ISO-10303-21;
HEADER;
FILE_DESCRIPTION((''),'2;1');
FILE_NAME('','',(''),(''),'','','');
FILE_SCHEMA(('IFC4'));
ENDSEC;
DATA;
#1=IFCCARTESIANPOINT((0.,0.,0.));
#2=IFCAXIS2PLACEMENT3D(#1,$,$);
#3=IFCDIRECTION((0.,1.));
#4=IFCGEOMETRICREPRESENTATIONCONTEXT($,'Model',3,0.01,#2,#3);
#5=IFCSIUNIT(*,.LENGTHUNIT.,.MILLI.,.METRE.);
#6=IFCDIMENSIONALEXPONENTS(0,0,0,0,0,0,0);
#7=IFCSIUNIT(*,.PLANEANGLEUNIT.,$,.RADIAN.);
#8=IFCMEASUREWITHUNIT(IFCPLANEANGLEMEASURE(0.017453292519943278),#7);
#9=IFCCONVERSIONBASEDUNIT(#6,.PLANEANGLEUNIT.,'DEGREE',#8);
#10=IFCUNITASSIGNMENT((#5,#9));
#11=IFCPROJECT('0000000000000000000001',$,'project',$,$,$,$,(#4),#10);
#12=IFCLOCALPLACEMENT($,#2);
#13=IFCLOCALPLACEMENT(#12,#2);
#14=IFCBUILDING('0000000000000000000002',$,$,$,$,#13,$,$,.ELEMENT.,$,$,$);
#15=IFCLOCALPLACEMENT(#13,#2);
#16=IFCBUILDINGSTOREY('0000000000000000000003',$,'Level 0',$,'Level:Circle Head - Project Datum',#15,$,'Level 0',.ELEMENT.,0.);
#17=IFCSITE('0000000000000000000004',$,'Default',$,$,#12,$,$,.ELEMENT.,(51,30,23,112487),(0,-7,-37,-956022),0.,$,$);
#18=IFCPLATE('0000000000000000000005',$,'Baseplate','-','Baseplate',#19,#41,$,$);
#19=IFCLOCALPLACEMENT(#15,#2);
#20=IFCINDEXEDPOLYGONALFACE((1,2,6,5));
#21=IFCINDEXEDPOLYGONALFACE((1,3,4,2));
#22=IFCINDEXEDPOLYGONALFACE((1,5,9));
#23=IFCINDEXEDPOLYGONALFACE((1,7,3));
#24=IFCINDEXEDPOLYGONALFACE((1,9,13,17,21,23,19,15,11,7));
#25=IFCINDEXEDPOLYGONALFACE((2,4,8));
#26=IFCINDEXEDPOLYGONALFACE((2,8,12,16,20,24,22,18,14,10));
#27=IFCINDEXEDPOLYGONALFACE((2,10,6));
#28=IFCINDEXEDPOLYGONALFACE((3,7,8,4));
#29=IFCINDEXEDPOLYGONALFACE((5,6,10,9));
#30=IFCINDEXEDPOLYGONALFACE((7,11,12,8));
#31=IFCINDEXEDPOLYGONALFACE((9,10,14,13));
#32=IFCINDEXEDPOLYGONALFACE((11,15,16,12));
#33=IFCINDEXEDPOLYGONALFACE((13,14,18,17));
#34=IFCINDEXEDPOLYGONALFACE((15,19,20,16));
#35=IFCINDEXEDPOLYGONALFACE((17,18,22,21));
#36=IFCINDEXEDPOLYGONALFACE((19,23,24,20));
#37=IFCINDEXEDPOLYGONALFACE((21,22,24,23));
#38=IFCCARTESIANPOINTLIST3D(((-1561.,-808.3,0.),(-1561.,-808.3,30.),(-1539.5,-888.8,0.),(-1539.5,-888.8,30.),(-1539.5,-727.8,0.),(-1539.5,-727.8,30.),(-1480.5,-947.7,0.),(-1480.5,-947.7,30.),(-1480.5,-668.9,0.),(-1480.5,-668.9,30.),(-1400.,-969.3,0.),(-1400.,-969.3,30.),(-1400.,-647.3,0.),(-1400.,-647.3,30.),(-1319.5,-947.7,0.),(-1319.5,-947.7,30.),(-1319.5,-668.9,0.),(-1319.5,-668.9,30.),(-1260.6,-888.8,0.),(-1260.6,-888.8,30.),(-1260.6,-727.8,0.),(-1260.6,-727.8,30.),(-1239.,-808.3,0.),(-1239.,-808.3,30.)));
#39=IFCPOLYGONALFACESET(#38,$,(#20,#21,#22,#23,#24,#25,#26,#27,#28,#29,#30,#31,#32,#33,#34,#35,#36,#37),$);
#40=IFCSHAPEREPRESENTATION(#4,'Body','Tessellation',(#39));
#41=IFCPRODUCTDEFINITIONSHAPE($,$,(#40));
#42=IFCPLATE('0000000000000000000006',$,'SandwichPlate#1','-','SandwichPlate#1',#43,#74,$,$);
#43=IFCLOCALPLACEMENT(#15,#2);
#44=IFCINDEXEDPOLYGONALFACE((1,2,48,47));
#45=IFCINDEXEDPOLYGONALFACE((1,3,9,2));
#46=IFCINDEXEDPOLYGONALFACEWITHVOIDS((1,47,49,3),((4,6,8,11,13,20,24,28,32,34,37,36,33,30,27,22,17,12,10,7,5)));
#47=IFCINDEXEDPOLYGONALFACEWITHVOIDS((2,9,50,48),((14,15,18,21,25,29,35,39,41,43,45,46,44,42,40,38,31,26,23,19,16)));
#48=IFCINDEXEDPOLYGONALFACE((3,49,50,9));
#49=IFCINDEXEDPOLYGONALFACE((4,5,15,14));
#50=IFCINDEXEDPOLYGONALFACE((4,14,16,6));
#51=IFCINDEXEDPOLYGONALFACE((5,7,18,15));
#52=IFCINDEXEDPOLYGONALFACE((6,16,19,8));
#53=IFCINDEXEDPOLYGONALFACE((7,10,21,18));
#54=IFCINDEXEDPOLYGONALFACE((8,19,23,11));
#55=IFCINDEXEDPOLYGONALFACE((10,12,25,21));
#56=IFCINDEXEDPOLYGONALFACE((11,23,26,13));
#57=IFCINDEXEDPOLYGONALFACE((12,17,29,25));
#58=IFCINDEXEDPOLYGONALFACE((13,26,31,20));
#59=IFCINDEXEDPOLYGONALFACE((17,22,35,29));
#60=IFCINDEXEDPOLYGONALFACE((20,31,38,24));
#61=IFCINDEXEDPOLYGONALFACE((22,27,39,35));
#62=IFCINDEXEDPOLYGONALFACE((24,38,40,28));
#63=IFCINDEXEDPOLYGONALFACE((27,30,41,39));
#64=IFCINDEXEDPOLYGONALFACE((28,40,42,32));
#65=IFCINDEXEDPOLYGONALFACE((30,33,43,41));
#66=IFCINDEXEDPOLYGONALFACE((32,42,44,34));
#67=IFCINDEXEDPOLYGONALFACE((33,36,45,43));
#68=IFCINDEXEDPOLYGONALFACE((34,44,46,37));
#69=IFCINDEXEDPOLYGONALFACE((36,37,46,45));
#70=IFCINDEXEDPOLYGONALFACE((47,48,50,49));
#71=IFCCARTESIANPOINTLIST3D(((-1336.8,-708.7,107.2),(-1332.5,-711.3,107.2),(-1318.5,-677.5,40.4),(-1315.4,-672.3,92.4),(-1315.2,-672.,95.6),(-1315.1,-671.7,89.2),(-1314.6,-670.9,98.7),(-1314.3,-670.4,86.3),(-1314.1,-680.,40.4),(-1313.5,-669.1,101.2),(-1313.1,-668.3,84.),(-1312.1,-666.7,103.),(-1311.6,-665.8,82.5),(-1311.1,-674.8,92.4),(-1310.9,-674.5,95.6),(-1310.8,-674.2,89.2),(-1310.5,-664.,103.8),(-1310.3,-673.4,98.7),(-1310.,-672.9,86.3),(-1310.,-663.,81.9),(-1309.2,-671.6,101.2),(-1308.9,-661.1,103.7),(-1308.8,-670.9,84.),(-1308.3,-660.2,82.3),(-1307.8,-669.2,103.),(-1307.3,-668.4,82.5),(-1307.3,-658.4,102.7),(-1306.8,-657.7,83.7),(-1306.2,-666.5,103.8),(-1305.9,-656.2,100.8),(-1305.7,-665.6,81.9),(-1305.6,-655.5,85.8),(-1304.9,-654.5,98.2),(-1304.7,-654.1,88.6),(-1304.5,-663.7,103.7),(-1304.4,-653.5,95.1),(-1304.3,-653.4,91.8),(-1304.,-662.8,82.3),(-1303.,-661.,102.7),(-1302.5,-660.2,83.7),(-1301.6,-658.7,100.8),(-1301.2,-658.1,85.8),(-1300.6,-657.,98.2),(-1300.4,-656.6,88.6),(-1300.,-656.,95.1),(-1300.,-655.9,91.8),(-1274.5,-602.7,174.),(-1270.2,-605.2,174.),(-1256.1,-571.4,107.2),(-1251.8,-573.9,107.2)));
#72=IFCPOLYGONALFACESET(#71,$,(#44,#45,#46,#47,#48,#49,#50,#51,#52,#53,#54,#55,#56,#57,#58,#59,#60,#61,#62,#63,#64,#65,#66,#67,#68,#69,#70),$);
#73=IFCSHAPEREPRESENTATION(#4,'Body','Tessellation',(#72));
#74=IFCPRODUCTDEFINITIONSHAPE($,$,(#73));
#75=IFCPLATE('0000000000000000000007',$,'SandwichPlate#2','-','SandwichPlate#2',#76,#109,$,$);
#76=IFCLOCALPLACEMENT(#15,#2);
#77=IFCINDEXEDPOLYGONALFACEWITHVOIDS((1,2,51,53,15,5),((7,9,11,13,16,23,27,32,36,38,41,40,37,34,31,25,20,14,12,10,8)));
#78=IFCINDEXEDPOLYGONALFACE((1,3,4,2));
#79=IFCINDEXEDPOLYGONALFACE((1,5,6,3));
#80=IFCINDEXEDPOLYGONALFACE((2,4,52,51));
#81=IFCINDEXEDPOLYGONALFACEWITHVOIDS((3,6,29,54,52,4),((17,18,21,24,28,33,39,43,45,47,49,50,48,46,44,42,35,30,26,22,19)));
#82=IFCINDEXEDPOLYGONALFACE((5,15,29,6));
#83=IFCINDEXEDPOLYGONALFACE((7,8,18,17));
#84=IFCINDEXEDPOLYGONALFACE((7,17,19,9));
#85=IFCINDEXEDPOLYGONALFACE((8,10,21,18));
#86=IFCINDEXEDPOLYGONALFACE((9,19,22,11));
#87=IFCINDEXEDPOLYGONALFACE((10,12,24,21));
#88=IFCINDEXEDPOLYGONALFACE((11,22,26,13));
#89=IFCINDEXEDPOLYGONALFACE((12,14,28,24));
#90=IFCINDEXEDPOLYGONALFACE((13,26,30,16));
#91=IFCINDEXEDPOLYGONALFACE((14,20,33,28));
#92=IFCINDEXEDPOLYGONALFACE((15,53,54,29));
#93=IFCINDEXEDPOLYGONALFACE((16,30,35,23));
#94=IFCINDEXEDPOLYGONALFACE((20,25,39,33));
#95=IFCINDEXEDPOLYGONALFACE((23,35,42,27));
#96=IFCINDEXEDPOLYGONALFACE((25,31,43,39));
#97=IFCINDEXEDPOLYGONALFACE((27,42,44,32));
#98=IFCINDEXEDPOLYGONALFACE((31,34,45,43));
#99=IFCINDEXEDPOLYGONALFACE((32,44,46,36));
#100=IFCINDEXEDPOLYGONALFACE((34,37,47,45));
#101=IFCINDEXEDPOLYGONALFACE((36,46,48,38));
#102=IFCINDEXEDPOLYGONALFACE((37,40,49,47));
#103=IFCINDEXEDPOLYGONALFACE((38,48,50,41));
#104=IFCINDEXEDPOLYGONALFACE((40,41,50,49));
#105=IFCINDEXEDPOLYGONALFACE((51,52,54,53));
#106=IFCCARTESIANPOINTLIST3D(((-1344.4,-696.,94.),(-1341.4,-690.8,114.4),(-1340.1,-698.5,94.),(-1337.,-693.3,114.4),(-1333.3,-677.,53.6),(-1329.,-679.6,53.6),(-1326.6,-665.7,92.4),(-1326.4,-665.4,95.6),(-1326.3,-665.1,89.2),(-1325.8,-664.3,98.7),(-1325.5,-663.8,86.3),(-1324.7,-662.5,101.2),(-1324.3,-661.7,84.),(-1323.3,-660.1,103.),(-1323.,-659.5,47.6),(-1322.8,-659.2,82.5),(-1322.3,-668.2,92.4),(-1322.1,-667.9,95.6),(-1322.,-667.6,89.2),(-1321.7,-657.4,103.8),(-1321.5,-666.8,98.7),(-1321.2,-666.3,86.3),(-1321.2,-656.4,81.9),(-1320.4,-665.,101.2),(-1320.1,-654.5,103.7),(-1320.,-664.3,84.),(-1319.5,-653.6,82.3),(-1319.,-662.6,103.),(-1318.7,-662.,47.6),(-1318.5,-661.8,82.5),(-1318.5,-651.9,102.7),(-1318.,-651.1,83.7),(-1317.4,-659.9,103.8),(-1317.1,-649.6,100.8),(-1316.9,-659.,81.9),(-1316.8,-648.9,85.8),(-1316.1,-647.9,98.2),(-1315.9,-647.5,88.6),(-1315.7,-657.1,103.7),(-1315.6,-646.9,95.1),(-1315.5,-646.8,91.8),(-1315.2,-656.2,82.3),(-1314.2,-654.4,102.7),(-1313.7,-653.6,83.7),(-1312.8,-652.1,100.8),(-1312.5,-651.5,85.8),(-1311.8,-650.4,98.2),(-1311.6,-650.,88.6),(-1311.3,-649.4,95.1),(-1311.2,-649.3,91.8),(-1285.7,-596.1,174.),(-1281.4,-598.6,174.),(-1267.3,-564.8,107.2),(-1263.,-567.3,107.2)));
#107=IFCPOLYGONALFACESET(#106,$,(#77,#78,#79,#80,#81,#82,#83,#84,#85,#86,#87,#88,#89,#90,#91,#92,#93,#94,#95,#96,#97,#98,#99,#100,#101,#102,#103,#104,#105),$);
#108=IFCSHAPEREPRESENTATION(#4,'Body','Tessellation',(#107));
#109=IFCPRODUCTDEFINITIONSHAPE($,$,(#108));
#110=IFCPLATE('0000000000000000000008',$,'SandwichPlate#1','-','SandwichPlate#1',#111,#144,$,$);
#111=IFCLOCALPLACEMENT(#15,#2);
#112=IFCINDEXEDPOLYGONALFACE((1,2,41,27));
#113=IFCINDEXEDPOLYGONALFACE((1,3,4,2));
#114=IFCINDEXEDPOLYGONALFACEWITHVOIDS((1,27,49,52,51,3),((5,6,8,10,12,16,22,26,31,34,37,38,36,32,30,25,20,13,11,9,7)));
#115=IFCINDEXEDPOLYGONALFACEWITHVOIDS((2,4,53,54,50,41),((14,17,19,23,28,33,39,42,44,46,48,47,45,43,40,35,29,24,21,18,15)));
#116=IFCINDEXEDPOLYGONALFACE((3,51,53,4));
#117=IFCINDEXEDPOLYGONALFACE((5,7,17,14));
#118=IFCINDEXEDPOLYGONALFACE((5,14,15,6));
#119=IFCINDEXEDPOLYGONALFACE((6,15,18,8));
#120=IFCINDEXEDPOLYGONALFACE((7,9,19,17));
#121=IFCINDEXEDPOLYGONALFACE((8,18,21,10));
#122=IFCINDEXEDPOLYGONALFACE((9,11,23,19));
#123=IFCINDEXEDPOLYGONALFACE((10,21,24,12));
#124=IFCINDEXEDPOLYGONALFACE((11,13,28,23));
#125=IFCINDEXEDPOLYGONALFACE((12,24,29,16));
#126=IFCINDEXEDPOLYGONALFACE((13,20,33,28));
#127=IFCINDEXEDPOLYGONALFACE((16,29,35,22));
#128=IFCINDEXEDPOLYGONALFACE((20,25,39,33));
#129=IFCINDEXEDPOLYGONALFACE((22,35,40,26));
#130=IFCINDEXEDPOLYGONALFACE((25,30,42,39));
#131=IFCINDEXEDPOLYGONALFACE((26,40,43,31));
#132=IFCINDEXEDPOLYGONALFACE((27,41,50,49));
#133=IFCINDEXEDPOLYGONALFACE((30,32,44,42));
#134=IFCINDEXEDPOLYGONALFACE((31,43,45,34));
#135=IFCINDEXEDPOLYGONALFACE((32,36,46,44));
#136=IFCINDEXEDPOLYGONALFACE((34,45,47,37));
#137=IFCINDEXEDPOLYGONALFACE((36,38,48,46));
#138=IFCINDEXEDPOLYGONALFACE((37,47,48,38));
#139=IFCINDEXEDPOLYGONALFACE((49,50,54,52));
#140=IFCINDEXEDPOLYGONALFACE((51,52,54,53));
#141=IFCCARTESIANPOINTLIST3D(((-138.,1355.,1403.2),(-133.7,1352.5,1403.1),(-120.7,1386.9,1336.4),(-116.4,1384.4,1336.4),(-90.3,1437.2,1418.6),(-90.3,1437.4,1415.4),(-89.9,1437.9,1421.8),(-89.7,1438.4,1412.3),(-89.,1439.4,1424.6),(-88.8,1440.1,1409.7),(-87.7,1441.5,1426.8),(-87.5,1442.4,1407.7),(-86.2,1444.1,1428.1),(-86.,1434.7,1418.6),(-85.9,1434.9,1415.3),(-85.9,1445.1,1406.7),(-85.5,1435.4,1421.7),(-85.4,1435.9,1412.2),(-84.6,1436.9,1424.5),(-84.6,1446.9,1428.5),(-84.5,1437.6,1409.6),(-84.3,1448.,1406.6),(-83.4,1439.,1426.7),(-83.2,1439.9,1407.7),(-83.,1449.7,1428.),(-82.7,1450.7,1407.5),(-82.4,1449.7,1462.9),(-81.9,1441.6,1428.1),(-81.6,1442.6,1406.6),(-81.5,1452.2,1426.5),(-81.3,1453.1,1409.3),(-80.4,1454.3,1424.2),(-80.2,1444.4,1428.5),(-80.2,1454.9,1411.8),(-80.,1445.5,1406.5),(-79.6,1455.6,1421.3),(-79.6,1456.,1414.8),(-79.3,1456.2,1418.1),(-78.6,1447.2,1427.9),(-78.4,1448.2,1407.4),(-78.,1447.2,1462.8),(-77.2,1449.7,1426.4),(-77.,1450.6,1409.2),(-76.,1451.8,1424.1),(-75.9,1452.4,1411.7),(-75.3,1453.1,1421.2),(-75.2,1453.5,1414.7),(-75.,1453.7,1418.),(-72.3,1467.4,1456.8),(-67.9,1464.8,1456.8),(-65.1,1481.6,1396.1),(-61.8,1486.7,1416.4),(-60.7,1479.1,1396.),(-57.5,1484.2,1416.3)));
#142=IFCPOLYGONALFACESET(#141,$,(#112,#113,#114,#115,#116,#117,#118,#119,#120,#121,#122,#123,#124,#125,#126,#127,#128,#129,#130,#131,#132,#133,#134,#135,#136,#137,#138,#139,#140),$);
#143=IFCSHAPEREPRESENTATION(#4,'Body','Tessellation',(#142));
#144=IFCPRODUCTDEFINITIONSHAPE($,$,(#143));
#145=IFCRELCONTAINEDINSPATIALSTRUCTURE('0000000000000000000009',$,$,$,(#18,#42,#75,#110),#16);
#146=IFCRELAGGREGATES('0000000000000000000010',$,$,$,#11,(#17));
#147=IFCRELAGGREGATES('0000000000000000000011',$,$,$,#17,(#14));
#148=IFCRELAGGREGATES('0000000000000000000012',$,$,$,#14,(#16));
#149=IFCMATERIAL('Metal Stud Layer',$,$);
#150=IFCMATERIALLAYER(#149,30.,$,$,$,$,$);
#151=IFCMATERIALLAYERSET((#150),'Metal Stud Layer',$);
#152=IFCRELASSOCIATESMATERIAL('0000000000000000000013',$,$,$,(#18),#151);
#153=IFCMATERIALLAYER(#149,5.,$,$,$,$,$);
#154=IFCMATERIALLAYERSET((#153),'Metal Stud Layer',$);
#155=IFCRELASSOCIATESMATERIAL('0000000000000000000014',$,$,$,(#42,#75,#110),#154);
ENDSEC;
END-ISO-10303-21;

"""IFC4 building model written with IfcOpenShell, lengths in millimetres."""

from ifc_helpers import new_model, entity, si_unit, converted_unit, point, direction, frame, frame_2d, origin, origin_with_axes, origin_2d_with_axis, place, context, project, spatial, polyline, circle_curve, line_curve, trimmed, segment, composite_curve, circle, outline, extrude, material, layer, layer_set, element, save


model = new_model("IFC4")

# Units and contexts
model_context = context("Model", 3, precision=0.01, world=origin(), true_north=direction((0.0, 1.0)))
ifc_project = project(units=[si_unit("LENGTHUNIT", "METRE", prefix="MILLI"), converted_unit("PLANEANGLEUNIT", "DEGREE", entity("IfcPlaneAngleMeasure", 0.017453292519943278), si_unit("PLANEANGLEUNIT", "RADIAN"), dimensions=[0, 0, 0, 0, 0, 0, 0])], contexts=[model_context])

# Site, building, storey
site_placement = place(None, origin())
site = spatial("IfcSite", under=ifc_project, at=site_placement, Name="Default", CompositionType="ELEMENT", RefLatitude=(51, 30, 23, 112487), RefLongitude=(0, -7, -37, -956022), RefElevation=0.0)
building_placement = place(site_placement, origin())
building = spatial("IfcBuilding", under=site, at=building_placement, CompositionType="ELEMENT")
storey_placement = place(building_placement, origin())
storey = spatial("IfcBuildingStorey", under=building, at=storey_placement, Name="Level 0", ObjectType="Level:Circle Head - Project Datum", LongName="Level 0", CompositionType="ELEMENT", Elevation=0.0)

# Plate, openings
ifc_material_1 = material(Name="Metal Stud Layer")
ifc_layer_1 = layer(ifc_material_1, 30.0)
ifc_layer_set_1 = layer_set([ifc_layer_1], Name="Metal Stud Layer")
ifc_layer_2 = layer(ifc_material_1, 5.0)
ifc_layer_set_2 = layer_set([ifc_layer_2], Name="Metal Stud Layer")
plate_1_placement = place(storey_placement, frame((-1319.5, -947.7, 30.0), z_axis=(0.0, 0.0, -1.0), x_axis=(-0.866025, -0.5, 0.0)))
plate_1 = element("IfcPlate", 1, at=plate_1_placement, inside=storey, material=ifc_layer_set_1, Name="Baseplate", Description="-", ObjectType="Baseplate", context=model_context, shape_type="SweptSolid", body=[
    extrude(outline(polyline([(161.0, 0.0), (161.0, 322.0), (-161.0, 322.0), (-161.0, 0.0), (161.0, 0.0)])), origin_with_axes(), (0.0, 0.0, 1.0), 30.0),
])
opening_1_placement = place(plate_1_placement, frame((0.0, 0.0, 0.0), z_axis=(0.0, 0.0, 1.0), x_axis=(1.0, 0.0, 0.0)))
element("IfcOpeningElement", 2, at=opening_1_placement, cuts=plate_1, ObjectType="Opening", context=model_context, shape_type="SweptSolid", body=[
    extrude(outline(composite_curve([segment(trimmed(line_curve((161.0, 0.0), (0.0, 1.0), 161.0), [point((161.0, 0.0))], [point((161.0, 161.0))], True, "CARTESIAN"), True, "CONTINUOUS"), segment(trimmed(circle_curve(frame_2d((0.0, 161.0), x_axis=(-1.0, 0.0)), 161.0), [point((161.0, 161.0))], [point((0.0, 0.0))], False, "CARTESIAN"), True, "CONTINUOUS"), segment(trimmed(line_curve((0.0, 0.0), (1.0, 0.0), 161.0), [point((0.0, 0.0))], [point((161.0, 0.0))], True, "CARTESIAN"), True, "CONTINUOUS")], self_intersect="UNKNOWN")), origin(), (0.0, 0.0, 1.0), 30.0),
])
opening_2_placement = place(plate_1_placement, frame((0.0, 0.0, 0.0), z_axis=(0.0, 0.0, 1.0), x_axis=(1.0, 0.0, 0.0)))
element("IfcOpeningElement", 3, at=opening_2_placement, cuts=plate_1, ObjectType="Opening", context=model_context, shape_type="SweptSolid", body=[
    extrude(outline(composite_curve([segment(trimmed(line_curve((161.0, 322.0), (-1.0, 0.0), 161.0), [point((161.0, 322.0))], [point((0.0, 322.0))], True, "CARTESIAN"), True, "CONTINUOUS"), segment(trimmed(circle_curve(frame_2d((0.0, 161.0), x_axis=(-1.0, 0.0)), 161.0), [point((0.0, 322.0))], [point((161.0, 161.0))], False, "CARTESIAN"), True, "CONTINUOUS"), segment(trimmed(line_curve((161.0, 161.0), (0.0, 1.0), 161.0), [point((161.0, 161.0))], [point((161.0, 322.0))], True, "CARTESIAN"), True, "CONTINUOUS")], self_intersect="UNKNOWN")), origin(), (0.0, 0.0, 1.0), 30.0),
])
opening_3_placement = place(plate_1_placement, frame((0.0, 0.0, 0.0), z_axis=(0.0, 0.0, 1.0), x_axis=(1.0, 0.0, 0.0)))
element("IfcOpeningElement", 4, at=opening_3_placement, cuts=plate_1, ObjectType="Opening", context=model_context, shape_type="SweptSolid", body=[
    extrude(outline(composite_curve([segment(trimmed(line_curve((-161.0, 322.0), (0.0, -1.0), 161.0), [point((-161.0, 322.0))], [point((-161.0, 161.0))], True, "CARTESIAN"), True, "CONTINUOUS"), segment(trimmed(circle_curve(frame_2d((0.0, 161.0), x_axis=(-1.0, 0.0)), 161.0), [point((-161.0, 161.0))], [point((0.0, 322.0))], False, "CARTESIAN"), True, "CONTINUOUS"), segment(trimmed(line_curve((0.0, 322.0), (-1.0, 0.0), 161.0), [point((0.0, 322.0))], [point((-161.0, 322.0))], True, "CARTESIAN"), True, "CONTINUOUS")], self_intersect="UNKNOWN")), origin(), (0.0, 0.0, 1.0), 30.0),
])
opening_4_placement = place(plate_1_placement, frame((0.0, 0.0, 0.0), z_axis=(0.0, 0.0, 1.0), x_axis=(1.0, 0.0, 0.0)))
element("IfcOpeningElement", 5, at=opening_4_placement, cuts=plate_1, ObjectType="Opening", context=model_context, shape_type="SweptSolid", body=[
    extrude(outline(composite_curve([segment(trimmed(line_curve((-161.0, 0.0), (1.0, 0.0), 161.0), [point((-161.0, 0.0))], [point((0.0, 0.0))], True, "CARTESIAN"), True, "CONTINUOUS"), segment(trimmed(circle_curve(frame_2d((0.0, 161.0), x_axis=(-1.0, 0.0)), 161.0), [point((0.0, 0.0))], [point((-161.0, 161.0))], False, "CARTESIAN"), True, "CONTINUOUS"), segment(trimmed(line_curve((-161.0, 161.0), (0.0, -1.0), 161.0), [point((-161.0, 161.0))], [point((-161.0, 0.0))], True, "CARTESIAN"), True, "CONTINUOUS")], self_intersect="UNKNOWN")), origin(), (0.0, 0.0, 1.0), 30.0),
])

# Plates, openings
plate_2_placement = place(storey_placement, frame((-1336.8, -708.7, 107.2), z_axis=(0.86208, -0.506772, 0.0), x_axis=(0.24181, 0.411348, -0.878818)))
plate_2 = element("IfcPlate", 6, at=plate_2_placement, inside=storey, material=ifc_layer_set_2, Name="SandwichPlate#1", Description="-", ObjectType="SandwichPlate#1", context=model_context, shape_type="SweptSolid", body=[
    extrude(outline(polyline([(0.0, 0.0), (76.0, 0.0), (76.0, 140.0), (0.0, 140.0), (0.0, 0.0)])), origin_with_axes(), (0.0, 0.0, 1.0), 5.0),
])
opening_5_placement = place(plate_2_placement, frame((38.0, 40.0, -0.5), z_axis=(0.0, 0.0, 1.0), x_axis=(0.0, 1.0, 0.0)))
element("IfcOpeningElement", 7, at=opening_5_placement, cuts=plate_2, ObjectType="Opening", context=model_context, shape_type="SweptSolid", body=[
    extrude(circle(Radius=11.0, at=origin_2d_with_axis()), origin(), (0.0, 0.0, 1.0), 6.0),
])
plate_3_placement = place(storey_placement, frame((-1348.0, -702.1, 107.2), z_axis=(0.86208, -0.506772, 0.0), x_axis=(0.24181, 0.411348, -0.878818)))
plate_3 = element("IfcPlate", 8, at=plate_3_placement, inside=storey, material=ifc_layer_set_2, Name="SandwichPlate#2", Description="-", ObjectType="SandwichPlate#2", context=model_context, shape_type="SweptSolid", body=[
    extrude(outline(polyline([(15.0, 0.0), (61.0, 0.0), (76.0, 15.0), (76.0, 140.0), (0.0, 140.0), (0.0, 15.0), (15.0, 0.0)])), origin_with_axes(), (0.0, 0.0, 1.0), 5.0),
])
opening_6_placement = place(plate_3_placement, frame((38.0, 40.0, -0.5), z_axis=(0.0, 0.0, 1.0), x_axis=(0.0, 1.0, 0.0)))
element("IfcOpeningElement", 9, at=opening_6_placement, cuts=plate_3, ObjectType="Opening", context=model_context, shape_type="SweptSolid", body=[
    extrude(circle(Radius=11.0, at=origin_2d_with_axis()), origin(), (0.0, 0.0, 1.0), 6.0),
])

# Plate, openings
plate_4_placement = place(storey_placement, frame((-58.4, 1493.0, 1403.2), z_axis=(0.865935, -0.499948, -0.014432), x_axis=(-0.22762, -0.419615, 0.878699)))
plate_4 = element("IfcPlate", 10, at=plate_4_placement, inside=storey, material=ifc_layer_set_2, Name="SandwichPlate#1", Description="-", ObjectType="SandwichPlate#1", context=model_context, shape_type="SweptSolid", body=[
    extrude(outline(polyline([(0.0, 0.0), (76.0, 0.0), (76.0, 140.0), (0.0, 140.0), (0.0, 0.0)])), origin_with_axes(), (0.0, 0.0, 1.0), 5.0),
])
opening_7_placement = place(plate_4_placement, frame((0.0, 0.0, 0.0), z_axis=(0.0, 0.0, 1.0), x_axis=(1.0, 0.0, 0.0)))
element("IfcOpeningElement", 11, at=opening_7_placement, cuts=plate_4, ObjectType="Opening", context=model_context, shape_type="SweptSolid", body=[
    extrude(outline(polyline([(0.0, 0.0), (15.0, 0.0), (0.0, 15.0), (0.0, 0.0)])), origin(), (0.0, 0.0, 1.0), 5.0),
])
opening_8_placement = place(plate_4_placement, frame((0.0, 0.0, 0.0), z_axis=(0.0, 0.0, 1.0), x_axis=(1.0, 0.0, 0.0)))
element("IfcOpeningElement", 12, at=opening_8_placement, cuts=plate_4, ObjectType="Opening", context=model_context, shape_type="SweptSolid", body=[
    extrude(outline(polyline([(76.0, 0.0), (76.0, 15.0), (61.0, 0.0), (76.0, 0.0)])), origin(), (0.0, 0.0, 1.0), 5.0),
])
opening_9_placement = place(plate_4_placement, frame((38.0, 40.0, -0.5), z_axis=(0.0, 0.0, 1.0), x_axis=(0.0, 1.0, 0.0)))
element("IfcOpeningElement", 13, at=opening_9_placement, cuts=plate_4, ObjectType="Opening", context=model_context, shape_type="SweptSolid", body=[
    extrude(circle(Radius=11.0, at=origin_2d_with_axis()), origin(), (0.0, 0.0, 1.0), 6.0),
])

save(model, "model.ifc")
